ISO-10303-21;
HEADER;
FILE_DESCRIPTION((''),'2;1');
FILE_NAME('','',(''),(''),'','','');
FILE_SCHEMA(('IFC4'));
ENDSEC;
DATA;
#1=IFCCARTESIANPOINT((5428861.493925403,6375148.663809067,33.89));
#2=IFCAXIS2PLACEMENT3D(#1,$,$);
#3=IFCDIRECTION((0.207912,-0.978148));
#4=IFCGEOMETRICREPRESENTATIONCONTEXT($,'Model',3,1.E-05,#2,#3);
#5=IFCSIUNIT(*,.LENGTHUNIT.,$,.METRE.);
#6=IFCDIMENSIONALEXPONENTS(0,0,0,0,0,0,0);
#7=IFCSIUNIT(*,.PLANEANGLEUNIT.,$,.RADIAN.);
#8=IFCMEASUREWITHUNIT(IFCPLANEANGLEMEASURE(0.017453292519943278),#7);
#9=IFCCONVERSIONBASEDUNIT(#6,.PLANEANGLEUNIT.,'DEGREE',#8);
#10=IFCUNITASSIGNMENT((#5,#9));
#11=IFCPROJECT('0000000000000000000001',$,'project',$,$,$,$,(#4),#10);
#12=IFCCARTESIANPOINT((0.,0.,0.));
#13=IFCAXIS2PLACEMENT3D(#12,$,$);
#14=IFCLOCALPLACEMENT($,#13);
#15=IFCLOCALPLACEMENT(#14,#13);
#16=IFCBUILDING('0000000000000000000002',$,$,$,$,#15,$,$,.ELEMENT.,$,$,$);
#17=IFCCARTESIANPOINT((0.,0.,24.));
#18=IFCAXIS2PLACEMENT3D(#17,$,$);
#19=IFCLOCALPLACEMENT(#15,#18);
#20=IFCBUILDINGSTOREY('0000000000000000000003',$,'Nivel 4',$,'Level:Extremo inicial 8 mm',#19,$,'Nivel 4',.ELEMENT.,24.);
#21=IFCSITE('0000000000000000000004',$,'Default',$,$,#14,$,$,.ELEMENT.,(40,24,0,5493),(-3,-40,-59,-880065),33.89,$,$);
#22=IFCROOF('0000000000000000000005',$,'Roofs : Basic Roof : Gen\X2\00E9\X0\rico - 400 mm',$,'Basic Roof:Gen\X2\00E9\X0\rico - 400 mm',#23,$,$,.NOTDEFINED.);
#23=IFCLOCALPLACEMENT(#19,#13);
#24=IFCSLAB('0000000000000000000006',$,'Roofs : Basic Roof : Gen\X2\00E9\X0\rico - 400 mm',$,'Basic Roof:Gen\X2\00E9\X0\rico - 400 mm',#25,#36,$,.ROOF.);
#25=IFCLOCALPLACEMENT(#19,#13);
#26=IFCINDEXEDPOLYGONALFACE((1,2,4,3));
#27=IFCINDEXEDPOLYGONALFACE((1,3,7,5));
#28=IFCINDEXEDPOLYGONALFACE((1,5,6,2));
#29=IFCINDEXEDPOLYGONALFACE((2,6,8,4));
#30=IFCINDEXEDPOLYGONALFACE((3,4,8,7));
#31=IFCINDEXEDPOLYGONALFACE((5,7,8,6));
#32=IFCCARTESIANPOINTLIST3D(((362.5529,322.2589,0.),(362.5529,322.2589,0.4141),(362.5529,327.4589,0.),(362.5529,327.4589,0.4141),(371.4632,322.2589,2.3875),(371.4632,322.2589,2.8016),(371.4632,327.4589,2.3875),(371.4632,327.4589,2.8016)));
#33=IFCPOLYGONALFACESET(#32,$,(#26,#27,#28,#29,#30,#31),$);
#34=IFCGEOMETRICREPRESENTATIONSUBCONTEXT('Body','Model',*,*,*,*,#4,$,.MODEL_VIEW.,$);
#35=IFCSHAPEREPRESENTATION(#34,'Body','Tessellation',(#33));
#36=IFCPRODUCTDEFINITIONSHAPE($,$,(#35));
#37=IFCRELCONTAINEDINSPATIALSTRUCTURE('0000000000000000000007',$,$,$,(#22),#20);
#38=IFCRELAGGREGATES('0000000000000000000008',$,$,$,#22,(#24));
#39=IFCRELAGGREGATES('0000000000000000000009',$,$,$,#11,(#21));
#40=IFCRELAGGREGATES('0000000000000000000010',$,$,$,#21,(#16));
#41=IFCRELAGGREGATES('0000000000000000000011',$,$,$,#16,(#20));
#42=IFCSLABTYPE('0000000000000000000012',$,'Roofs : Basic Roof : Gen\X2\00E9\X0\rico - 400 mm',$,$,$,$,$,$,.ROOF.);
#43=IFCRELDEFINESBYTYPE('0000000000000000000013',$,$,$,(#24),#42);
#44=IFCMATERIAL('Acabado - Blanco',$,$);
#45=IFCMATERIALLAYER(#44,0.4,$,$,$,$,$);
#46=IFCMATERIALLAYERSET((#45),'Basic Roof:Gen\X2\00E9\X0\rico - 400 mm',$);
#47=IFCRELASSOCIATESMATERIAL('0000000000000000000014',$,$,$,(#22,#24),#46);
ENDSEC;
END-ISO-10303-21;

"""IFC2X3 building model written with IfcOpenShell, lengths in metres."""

from ifc_helpers import new_model, entity, si_unit, converted_unit, direction, frame, frame_2d, origin, place, context, subcontext, project, spatial, rectangle, extrude, material, layer, layer_set, type_object, element, aggregate, save


model = new_model("IFC2X3")

# Units and contexts
model_context = context("Model", 3, precision=1e-05, world=frame((5428861.493925403, 6375148.663809067, 33.89)), true_north=direction((0.207912, -0.978148)))
body_context = subcontext(model_context, "Body", "Model", "MODEL_VIEW")
ifc_project = project(units=[si_unit("LENGTHUNIT", "METRE"), converted_unit("PLANEANGLEUNIT", "DEGREE", entity("IfcPlaneAngleMeasure", 0.017453292519943278), si_unit("PLANEANGLEUNIT", "RADIAN"), dimensions=[0, 0, 0, 0, 0, 0, 0])], contexts=[model_context])

# Site, building, storey
site_placement = place(None, origin())
site = spatial("IfcSite", under=ifc_project, at=site_placement, Name="Default", CompositionType="ELEMENT", RefLatitude=(40, 24, 0, 5493), RefLongitude=(-3, -40, -59, -880065), RefElevation=33.89)
building_placement = place(site_placement, origin())
building = spatial("IfcBuilding", under=site, at=building_placement, CompositionType="ELEMENT")
storey_placement = place(building_placement, frame((0.0, 0.0, 24.0)))
storey = spatial("IfcBuildingStorey", under=building, at=storey_placement, Name="Nivel 4", ObjectType="Level:Extremo inicial 8 mm", LongName="Nivel 4", CompositionType="ELEMENT", Elevation=24.0)

# Shared definitions
ifc_material = material(Name="Acabado - Blanco")
ifc_layer = layer(ifc_material, 0.4)
ifc_layer_set = layer_set([ifc_layer], Name="Basic Roof:Genérico - 400 mm")
slab_type = type_object("IfcSlabType", Name="Roofs : Basic Roof : Genérico - 400 mm", PredefinedType="ROOF")

# Roof, slab
roof_1_placement = place(storey_placement, frame((362.5529, 322.2589, 0.0)))
roof_1 = element("IfcRoof", 1, at=roof_1_placement, inside=storey, material=ifc_layer_set, Name="Roofs : Basic Roof : Genérico - 400 mm", ObjectType="Basic Roof:Genérico - 400 mm", ShapeType="NOTDEFINED")
slab_1_placement = place(roof_1_placement, origin())
slab_1 = element("IfcSlab", 2, at=slab_1_placement, type_object=slab_type, material=ifc_layer_set, Name="Roofs : Basic Roof : Genérico - 400 mm", ObjectType="Basic Roof:Genérico - 400 mm", PredefinedType="ROOF", context=body_context, shape_type="SweptSolid", body=[
    extrude(rectangle(XDim=9.2246, YDim=5.2, at=frame_2d((0.0, 0.0), x_axis=(-1.0, 0.0))), frame((4.4551, 2.6, 1.1937), z_axis=(-0.258819, 0.0, 0.965926), x_axis=(0.965926, 0.0, 0.258819)), (0.258819, 0.0, 0.965926), 0.4141),
])
aggregate(roof_1, [slab_1])

save(model, "model.ifc")
